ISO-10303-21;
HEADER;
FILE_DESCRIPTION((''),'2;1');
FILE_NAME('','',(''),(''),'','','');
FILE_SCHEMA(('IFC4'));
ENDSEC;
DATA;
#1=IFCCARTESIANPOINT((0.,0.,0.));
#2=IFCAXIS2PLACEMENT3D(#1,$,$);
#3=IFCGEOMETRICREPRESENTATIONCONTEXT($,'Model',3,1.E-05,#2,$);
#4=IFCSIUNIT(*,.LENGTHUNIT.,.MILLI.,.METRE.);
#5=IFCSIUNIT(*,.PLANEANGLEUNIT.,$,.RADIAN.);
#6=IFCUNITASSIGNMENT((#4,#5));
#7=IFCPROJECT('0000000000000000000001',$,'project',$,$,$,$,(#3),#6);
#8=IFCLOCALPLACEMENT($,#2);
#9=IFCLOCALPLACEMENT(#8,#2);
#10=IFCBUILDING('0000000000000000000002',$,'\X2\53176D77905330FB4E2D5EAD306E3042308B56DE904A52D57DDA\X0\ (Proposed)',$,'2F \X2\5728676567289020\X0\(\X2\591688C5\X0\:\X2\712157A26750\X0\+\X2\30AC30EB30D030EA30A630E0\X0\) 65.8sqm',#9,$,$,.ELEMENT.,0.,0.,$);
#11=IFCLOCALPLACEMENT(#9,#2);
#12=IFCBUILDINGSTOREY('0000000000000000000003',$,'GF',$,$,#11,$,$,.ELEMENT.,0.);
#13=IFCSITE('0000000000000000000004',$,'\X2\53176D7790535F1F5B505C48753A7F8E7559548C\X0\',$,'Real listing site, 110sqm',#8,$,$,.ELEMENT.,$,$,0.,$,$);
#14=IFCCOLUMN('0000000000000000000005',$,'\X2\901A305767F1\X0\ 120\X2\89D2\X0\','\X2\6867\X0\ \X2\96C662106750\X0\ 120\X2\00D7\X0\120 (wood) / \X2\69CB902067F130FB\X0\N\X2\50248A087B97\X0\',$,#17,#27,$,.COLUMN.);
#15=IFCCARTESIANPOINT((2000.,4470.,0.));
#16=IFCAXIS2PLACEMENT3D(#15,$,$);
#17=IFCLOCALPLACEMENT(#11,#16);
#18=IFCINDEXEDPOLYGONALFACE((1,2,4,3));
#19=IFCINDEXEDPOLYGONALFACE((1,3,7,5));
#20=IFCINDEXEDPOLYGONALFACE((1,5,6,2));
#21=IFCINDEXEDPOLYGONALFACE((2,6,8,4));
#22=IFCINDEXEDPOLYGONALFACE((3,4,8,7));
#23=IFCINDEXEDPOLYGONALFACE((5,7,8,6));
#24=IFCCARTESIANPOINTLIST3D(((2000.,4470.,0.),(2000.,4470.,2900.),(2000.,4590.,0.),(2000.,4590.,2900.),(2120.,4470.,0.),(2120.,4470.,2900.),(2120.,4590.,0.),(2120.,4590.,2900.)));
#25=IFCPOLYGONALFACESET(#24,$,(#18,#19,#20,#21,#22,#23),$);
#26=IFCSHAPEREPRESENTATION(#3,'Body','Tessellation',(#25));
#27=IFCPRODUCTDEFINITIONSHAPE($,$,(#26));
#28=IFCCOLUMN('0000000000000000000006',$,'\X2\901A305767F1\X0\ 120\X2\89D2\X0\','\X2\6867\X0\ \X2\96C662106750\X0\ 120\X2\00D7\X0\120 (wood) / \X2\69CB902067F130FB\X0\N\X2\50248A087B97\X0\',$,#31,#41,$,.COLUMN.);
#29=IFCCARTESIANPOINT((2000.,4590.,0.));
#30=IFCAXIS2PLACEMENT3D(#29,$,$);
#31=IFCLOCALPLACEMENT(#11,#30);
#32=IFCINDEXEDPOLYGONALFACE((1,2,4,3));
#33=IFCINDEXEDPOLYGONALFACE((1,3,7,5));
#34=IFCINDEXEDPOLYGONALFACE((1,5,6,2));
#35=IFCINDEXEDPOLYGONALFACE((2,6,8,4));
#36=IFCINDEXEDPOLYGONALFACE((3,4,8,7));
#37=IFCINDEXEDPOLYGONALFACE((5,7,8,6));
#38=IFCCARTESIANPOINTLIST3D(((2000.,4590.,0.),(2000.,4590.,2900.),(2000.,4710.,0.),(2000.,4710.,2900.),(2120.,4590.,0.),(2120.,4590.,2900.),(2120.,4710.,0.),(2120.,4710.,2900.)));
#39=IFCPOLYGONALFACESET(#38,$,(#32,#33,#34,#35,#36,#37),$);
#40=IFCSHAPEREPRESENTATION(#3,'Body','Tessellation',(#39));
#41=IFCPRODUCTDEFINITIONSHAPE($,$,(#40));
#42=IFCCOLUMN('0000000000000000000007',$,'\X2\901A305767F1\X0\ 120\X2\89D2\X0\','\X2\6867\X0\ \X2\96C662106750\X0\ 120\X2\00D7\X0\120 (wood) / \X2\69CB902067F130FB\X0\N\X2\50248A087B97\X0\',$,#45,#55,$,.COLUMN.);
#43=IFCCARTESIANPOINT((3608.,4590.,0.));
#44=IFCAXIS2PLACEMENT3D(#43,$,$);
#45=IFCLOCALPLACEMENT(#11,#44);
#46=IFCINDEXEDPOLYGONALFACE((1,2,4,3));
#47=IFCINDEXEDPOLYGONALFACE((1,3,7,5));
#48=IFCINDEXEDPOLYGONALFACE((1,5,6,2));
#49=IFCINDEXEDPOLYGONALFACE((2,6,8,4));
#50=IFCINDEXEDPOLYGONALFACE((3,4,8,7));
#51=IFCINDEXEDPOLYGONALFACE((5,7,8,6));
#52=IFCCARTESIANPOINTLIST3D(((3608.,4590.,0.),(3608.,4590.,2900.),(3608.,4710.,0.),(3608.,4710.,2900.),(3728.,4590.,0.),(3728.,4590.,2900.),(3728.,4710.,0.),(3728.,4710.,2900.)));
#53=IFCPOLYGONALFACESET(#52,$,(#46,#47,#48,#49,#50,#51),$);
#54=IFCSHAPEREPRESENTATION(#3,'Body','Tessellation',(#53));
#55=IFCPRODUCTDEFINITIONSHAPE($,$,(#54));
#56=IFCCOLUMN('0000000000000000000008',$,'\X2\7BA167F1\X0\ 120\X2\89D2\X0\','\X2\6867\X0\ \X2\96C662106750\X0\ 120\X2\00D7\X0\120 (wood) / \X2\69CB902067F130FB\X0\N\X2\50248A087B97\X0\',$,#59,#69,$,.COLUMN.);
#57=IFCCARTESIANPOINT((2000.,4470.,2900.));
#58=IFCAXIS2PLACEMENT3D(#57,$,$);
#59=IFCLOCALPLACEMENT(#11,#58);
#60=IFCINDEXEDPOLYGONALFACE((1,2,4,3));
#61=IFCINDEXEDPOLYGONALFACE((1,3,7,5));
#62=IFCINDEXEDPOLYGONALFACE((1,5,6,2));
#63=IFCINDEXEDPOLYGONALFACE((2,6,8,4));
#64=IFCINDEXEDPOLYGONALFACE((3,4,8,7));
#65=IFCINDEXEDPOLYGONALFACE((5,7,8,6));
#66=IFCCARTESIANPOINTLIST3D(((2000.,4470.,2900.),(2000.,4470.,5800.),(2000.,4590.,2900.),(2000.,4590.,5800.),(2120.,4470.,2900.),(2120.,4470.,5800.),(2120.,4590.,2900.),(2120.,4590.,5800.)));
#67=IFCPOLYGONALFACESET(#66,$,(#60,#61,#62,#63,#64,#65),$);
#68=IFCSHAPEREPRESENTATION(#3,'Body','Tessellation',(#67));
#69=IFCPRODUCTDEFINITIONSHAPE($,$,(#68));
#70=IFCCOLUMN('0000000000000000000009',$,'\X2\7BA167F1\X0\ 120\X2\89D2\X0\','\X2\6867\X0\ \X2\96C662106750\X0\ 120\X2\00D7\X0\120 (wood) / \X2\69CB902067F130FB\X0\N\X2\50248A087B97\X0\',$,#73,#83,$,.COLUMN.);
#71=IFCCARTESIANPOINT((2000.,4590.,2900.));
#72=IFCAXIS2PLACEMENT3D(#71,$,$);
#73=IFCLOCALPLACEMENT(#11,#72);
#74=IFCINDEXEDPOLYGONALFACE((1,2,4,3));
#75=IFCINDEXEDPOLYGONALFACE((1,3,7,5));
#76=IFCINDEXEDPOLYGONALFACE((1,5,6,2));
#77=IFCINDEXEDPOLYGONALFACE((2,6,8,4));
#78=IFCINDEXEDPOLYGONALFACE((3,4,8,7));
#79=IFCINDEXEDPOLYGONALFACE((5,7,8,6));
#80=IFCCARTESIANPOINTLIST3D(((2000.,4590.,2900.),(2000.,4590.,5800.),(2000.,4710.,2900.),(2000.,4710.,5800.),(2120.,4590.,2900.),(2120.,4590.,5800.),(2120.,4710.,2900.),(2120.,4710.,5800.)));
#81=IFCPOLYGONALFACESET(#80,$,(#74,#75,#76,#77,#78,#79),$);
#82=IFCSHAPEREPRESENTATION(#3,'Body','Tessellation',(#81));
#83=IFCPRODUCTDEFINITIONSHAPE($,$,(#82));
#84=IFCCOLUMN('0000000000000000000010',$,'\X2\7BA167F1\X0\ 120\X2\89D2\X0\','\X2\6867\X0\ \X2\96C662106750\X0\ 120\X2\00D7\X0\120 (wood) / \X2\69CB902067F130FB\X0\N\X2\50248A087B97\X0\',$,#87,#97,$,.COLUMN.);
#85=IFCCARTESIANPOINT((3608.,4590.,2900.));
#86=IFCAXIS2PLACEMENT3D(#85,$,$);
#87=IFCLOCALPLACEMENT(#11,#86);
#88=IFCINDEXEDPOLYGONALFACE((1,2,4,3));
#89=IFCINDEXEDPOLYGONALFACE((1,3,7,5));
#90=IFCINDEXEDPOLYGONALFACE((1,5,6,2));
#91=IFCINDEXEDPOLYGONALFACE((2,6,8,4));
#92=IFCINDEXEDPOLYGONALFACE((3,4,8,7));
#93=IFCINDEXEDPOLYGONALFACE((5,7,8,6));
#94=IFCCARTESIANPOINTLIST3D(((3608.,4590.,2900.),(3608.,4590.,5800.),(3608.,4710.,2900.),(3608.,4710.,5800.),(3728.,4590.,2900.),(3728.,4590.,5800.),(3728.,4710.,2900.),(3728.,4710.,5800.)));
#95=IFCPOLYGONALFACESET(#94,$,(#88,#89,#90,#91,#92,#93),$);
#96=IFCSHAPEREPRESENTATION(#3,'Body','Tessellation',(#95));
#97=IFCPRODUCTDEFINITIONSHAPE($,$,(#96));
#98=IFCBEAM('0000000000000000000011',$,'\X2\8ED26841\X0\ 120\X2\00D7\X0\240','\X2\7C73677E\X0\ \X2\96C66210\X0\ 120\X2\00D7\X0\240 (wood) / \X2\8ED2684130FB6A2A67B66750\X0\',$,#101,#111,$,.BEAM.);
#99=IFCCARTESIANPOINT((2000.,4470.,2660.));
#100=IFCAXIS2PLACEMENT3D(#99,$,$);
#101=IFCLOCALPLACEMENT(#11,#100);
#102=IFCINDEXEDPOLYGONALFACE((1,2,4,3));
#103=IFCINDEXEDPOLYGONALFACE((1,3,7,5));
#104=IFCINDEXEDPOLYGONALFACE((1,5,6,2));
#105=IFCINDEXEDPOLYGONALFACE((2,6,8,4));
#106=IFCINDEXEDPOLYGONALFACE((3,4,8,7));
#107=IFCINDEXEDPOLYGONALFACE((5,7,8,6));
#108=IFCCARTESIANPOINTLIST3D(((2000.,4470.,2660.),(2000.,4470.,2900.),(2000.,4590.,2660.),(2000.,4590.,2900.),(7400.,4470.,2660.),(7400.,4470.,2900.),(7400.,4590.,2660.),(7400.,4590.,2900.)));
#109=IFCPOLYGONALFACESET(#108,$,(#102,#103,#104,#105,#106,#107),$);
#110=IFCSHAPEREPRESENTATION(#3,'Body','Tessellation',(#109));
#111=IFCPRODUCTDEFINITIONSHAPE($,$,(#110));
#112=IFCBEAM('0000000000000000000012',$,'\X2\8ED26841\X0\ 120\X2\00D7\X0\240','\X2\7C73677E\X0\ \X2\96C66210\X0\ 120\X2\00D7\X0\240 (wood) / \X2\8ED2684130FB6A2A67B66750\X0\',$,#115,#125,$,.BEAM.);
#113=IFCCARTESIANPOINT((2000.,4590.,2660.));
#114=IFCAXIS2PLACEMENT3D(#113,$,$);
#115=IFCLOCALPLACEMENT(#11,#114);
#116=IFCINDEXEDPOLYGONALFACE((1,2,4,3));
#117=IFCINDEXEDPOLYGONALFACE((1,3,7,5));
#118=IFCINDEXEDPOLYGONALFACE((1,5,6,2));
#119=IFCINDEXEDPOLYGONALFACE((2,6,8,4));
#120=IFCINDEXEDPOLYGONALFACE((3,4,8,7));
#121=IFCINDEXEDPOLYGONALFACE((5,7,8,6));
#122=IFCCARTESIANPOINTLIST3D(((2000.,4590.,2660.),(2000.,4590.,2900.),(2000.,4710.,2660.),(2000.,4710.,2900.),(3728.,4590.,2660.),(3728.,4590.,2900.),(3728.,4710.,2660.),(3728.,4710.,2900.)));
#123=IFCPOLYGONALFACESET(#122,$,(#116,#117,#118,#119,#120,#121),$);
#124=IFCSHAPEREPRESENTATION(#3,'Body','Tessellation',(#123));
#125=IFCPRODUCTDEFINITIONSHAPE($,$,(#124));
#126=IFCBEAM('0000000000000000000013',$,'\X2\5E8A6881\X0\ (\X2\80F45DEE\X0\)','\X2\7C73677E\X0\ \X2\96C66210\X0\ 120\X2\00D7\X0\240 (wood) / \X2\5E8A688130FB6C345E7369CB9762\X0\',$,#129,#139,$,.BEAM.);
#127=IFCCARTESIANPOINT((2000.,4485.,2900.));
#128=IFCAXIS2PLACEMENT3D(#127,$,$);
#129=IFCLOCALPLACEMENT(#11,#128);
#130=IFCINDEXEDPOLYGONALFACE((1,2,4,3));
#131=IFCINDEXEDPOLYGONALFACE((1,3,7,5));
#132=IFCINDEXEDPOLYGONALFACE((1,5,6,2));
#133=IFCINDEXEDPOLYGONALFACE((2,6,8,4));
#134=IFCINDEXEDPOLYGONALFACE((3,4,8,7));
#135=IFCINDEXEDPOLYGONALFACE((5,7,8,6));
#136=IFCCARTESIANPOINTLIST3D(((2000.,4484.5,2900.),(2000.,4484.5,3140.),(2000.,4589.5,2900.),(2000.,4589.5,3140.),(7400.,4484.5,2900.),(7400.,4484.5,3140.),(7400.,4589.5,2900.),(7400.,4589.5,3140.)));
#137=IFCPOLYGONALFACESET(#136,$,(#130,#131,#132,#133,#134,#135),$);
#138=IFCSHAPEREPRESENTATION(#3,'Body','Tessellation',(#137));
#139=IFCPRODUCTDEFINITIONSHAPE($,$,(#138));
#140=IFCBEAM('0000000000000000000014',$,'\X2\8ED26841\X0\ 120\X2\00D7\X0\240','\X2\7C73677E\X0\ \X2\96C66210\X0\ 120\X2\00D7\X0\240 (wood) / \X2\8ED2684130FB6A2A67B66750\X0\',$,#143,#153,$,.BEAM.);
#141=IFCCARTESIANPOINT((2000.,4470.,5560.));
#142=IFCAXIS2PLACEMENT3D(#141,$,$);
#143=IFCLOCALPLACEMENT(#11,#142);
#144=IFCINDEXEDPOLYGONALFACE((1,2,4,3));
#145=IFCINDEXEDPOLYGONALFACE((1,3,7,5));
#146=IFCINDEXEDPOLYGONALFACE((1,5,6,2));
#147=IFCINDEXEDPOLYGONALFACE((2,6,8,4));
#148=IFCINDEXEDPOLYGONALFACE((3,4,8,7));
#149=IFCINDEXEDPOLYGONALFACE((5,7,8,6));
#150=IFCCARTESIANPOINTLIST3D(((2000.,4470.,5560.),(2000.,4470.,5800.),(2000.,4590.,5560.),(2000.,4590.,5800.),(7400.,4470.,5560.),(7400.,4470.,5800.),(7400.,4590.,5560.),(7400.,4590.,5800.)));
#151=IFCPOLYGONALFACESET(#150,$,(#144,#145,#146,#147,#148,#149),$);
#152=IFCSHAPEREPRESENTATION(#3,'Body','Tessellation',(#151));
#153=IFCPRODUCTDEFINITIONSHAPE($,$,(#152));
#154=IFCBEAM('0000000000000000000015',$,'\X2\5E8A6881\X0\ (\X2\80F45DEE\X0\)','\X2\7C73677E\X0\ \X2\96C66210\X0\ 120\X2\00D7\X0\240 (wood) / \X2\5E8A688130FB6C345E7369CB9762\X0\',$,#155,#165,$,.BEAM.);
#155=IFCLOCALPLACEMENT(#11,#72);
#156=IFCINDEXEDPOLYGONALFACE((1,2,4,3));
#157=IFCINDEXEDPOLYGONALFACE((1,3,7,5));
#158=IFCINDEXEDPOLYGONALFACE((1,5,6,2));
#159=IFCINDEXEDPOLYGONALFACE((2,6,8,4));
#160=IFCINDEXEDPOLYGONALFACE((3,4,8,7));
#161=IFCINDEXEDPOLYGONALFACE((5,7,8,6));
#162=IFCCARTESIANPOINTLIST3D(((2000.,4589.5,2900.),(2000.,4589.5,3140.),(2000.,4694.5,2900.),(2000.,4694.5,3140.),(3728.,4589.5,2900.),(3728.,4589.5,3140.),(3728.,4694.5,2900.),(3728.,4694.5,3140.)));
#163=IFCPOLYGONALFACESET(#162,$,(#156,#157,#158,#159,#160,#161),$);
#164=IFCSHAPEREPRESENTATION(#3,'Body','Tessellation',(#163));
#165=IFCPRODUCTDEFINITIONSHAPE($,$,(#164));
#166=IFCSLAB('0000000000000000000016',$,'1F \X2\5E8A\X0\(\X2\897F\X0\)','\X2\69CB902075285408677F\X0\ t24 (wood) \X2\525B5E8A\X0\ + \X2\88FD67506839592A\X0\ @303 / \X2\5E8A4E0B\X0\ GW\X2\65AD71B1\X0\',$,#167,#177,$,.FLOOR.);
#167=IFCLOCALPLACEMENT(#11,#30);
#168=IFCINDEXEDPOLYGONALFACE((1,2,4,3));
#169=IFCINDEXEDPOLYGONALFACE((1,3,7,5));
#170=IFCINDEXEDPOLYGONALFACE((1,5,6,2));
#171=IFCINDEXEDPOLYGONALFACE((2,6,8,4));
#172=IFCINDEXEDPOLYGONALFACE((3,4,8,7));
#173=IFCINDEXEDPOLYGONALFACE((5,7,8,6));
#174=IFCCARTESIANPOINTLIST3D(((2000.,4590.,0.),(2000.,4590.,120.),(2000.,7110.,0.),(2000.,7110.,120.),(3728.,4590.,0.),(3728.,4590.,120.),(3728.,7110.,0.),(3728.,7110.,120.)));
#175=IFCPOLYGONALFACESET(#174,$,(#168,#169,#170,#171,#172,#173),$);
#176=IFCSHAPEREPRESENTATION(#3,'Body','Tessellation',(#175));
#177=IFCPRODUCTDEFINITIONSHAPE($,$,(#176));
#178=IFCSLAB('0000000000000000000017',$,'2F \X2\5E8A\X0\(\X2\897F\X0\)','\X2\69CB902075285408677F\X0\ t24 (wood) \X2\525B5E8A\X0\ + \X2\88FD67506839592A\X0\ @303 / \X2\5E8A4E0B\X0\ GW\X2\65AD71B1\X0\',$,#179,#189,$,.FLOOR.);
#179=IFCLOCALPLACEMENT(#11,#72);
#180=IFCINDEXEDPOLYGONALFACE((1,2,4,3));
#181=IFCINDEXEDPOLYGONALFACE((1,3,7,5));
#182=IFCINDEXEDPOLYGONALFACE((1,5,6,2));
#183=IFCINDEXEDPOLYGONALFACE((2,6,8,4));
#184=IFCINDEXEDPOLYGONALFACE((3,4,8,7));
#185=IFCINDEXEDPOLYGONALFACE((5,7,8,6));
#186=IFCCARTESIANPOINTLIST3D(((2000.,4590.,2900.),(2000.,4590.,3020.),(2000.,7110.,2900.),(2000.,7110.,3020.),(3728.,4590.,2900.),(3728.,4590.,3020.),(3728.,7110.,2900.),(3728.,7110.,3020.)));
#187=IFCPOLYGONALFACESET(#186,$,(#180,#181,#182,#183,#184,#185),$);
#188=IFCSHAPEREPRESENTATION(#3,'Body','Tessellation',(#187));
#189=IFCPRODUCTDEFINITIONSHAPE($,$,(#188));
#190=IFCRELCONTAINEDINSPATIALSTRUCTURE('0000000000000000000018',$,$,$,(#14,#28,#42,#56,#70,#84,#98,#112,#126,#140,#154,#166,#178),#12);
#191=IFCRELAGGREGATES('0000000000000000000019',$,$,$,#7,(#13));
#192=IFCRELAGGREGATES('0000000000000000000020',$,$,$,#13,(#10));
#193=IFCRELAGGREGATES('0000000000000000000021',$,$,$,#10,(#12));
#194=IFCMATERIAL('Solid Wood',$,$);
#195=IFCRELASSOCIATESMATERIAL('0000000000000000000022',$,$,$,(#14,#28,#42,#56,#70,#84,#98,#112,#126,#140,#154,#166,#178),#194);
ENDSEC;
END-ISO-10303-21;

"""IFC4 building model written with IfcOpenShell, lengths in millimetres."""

from ifc_helpers import new_model, si_unit, frame, frame_2d, origin, place, context, project, spatial, rectangle, extrude, material, element, save


model = new_model("IFC4")

# Units and contexts
model_context = context("Model", 3, precision=1e-05, world=origin())
ifc_project = project(units=[si_unit("LENGTHUNIT", "METRE", prefix="MILLI"), si_unit("PLANEANGLEUNIT", "RADIAN")], contexts=[model_context])

# Site, building, storey
site_placement = place(None, origin())
site = spatial("IfcSite", under=ifc_project, at=site_placement, Name="北海道弟子屈町美留和", ObjectType="Real listing site, 110sqm", CompositionType="ELEMENT", RefElevation=0.0)
building_placement = place(site_placement, origin())
building = spatial("IfcBuilding", under=site, at=building_placement, Name="北海道・中庭のある回遊動線 (Proposed)", ObjectType="2F 在来木造(外装:無垢材+ガルバリウム) 65.8sqm", CompositionType="ELEMENT", ElevationOfRefHeight=0.0, ElevationOfTerrain=0.0)
storey_placement = place(building_placement, origin())
storey = spatial("IfcBuildingStorey", under=building, at=storey_placement, Name="GF", CompositionType="ELEMENT", Elevation=0.0)

# Columns
ifc_material_1 = material(Name="Solid Wood")
column_1_placement = place(storey_placement, frame((2000.0, 4470.0, 0.0)))
element("IfcColumn", 1, at=column_1_placement, inside=storey, material=ifc_material_1, Name="通し柱 120角", Description="桧 集成材 120×120 (wood) / 構造柱・N値計算", PredefinedType="COLUMN", context=model_context, shape_type="SweptSolid", body=[
    extrude(rectangle(XDim=120.0, YDim=120.0, at=frame_2d((60.0, 60.0))), frame((2000.0, 4470.0, 0.0)), (0.0, 0.0, 1.0), 2900.0),
])
column_2_placement = place(storey_placement, frame((2000.0, 4590.0, 0.0)))
element("IfcColumn", 2, at=column_2_placement, inside=storey, material=ifc_material_1, Name="通し柱 120角", Description="桧 集成材 120×120 (wood) / 構造柱・N値計算", PredefinedType="COLUMN", context=model_context, shape_type="SweptSolid", body=[
    extrude(rectangle(XDim=120.0, YDim=120.0, at=frame_2d((60.0, 60.0))), frame((2000.0, 4590.0, 0.0)), (0.0, 0.0, 1.0), 2900.0),
])
column_3_placement = place(storey_placement, frame((3608.0, 4590.0, 0.0)))
element("IfcColumn", 3, at=column_3_placement, inside=storey, material=ifc_material_1, Name="通し柱 120角", Description="桧 集成材 120×120 (wood) / 構造柱・N値計算", PredefinedType="COLUMN", context=model_context, shape_type="SweptSolid", body=[
    extrude(rectangle(XDim=120.0, YDim=120.0, at=frame_2d((60.0, 60.0))), frame((3608.0, 4590.0, 0.0)), (0.0, 0.0, 1.0), 2900.0),
])
column_4_placement = place(storey_placement, frame((2000.0, 4470.0, 2900.0)))
element("IfcColumn", 4, at=column_4_placement, inside=storey, material=ifc_material_1, Name="管柱 120角", Description="桧 集成材 120×120 (wood) / 構造柱・N値計算", PredefinedType="COLUMN", context=model_context, shape_type="SweptSolid", body=[
    extrude(rectangle(XDim=120.0, YDim=120.0, at=frame_2d((60.0, 60.0))), frame((2000.0, 4470.0, 2900.0)), (0.0, 0.0, 1.0), 2900.0),
])
column_5_placement = place(storey_placement, frame((2000.0, 4590.0, 2900.0)))
element("IfcColumn", 5, at=column_5_placement, inside=storey, material=ifc_material_1, Name="管柱 120角", Description="桧 集成材 120×120 (wood) / 構造柱・N値計算", PredefinedType="COLUMN", context=model_context, shape_type="SweptSolid", body=[
    extrude(rectangle(XDim=120.0, YDim=120.0, at=frame_2d((60.0, 60.0))), frame((2000.0, 4590.0, 2900.0)), (0.0, 0.0, 1.0), 2900.0),
])
column_6_placement = place(storey_placement, frame((3608.0, 4590.0, 2900.0)))
element("IfcColumn", 6, at=column_6_placement, inside=storey, material=ifc_material_1, Name="管柱 120角", Description="桧 集成材 120×120 (wood) / 構造柱・N値計算", PredefinedType="COLUMN", context=model_context, shape_type="SweptSolid", body=[
    extrude(rectangle(XDim=120.0, YDim=120.0, at=frame_2d((60.0, 60.0))), frame((3608.0, 4590.0, 2900.0)), (0.0, 0.0, 1.0), 2900.0),
])

# Beams
beam_1_placement = place(storey_placement, frame((2000.0, 4470.0, 2660.0)))
element("IfcBeam", 7, at=beam_1_placement, inside=storey, material=ifc_material_1, Name="軒桁 120×240", Description="米松 集成 120×240 (wood) / 軒桁・横架材", PredefinedType="BEAM", context=model_context, shape_type="SweptSolid", body=[
    extrude(rectangle(XDim=5400.0, YDim=120.0, at=frame_2d((2700.0, 60.0))), frame((2000.0, 4470.0, 2660.0)), (0.0, 0.0, 1.0), 240.0),
])
beam_2_placement = place(storey_placement, frame((2000.0, 4590.0, 2660.0)))
element("IfcBeam", 8, at=beam_2_placement, inside=storey, material=ifc_material_1, Name="軒桁 120×240", Description="米松 集成 120×240 (wood) / 軒桁・横架材", PredefinedType="BEAM", context=model_context, shape_type="SweptSolid", body=[
    extrude(rectangle(XDim=1728.0, YDim=120.0, at=frame_2d((864.0, 60.0))), frame((2000.0, 4590.0, 2660.0)), (0.0, 0.0, 1.0), 240.0),
])
beam_3_placement = place(storey_placement, frame((2000.0, 4485.0, 2900.0)))
element("IfcBeam", 9, at=beam_3_placement, inside=storey, material=ifc_material_1, Name="床梁 (胴差)", Description="米松 集成 120×240 (wood) / 床梁・水平構面", PredefinedType="BEAM", context=model_context, shape_type="SweptSolid", body=[
    extrude(rectangle(XDim=5400.0, YDim=105.0, at=frame_2d((2700.0, 52.0))), frame((2000.0, 4485.0, 2900.0)), (0.0, 0.0, 1.0), 240.0),
])
beam_4_placement = place(storey_placement, frame((2000.0, 4470.0, 5560.0)))
element("IfcBeam", 10, at=beam_4_placement, inside=storey, material=ifc_material_1, Name="軒桁 120×240", Description="米松 集成 120×240 (wood) / 軒桁・横架材", PredefinedType="BEAM", context=model_context, shape_type="SweptSolid", body=[
    extrude(rectangle(XDim=5400.0, YDim=120.0, at=frame_2d((2700.0, 60.0))), frame((2000.0, 4470.0, 5560.0)), (0.0, 0.0, 1.0), 240.0),
])
beam_5_placement = place(storey_placement, frame((2000.0, 4590.0, 2900.0)))
element("IfcBeam", 11, at=beam_5_placement, inside=storey, material=ifc_material_1, Name="床梁 (胴差)", Description="米松 集成 120×240 (wood) / 床梁・水平構面", PredefinedType="BEAM", context=model_context, shape_type="SweptSolid", body=[
    extrude(rectangle(XDim=1728.0, YDim=105.0, at=frame_2d((864.0, 52.0))), frame((2000.0, 4590.0, 2900.0)), (0.0, 0.0, 1.0), 240.0),
])

# Slabs
slab_1_placement = place(storey_placement, frame((2000.0, 4590.0, 0.0)))
element("IfcSlab", 12, at=slab_1_placement, inside=storey, material=ifc_material_1, Name="1F 床(西)", Description="構造用合板 t24 (wood) 剛床 + 製材根太 @303 / 床下 GW断熱", PredefinedType="FLOOR", context=model_context, shape_type="SweptSolid", body=[
    extrude(rectangle(XDim=1728.0, YDim=2520.0, at=frame_2d((864.0, 1260.0))), frame((2000.0, 4590.0, 0.0)), (0.0, 0.0, 1.0), 120.0),
])
slab_2_placement = place(storey_placement, frame((2000.0, 4590.0, 2900.0)))
element("IfcSlab", 13, at=slab_2_placement, inside=storey, material=ifc_material_1, Name="2F 床(西)", Description="構造用合板 t24 (wood) 剛床 + 製材根太 @303 / 床下 GW断熱", PredefinedType="FLOOR", context=model_context, shape_type="SweptSolid", body=[
    extrude(rectangle(XDim=1728.0, YDim=2520.0, at=frame_2d((864.0, 1260.0))), frame((2000.0, 4590.0, 2900.0)), (0.0, 0.0, 1.0), 120.0),
])

save(model, "model.ifc")
